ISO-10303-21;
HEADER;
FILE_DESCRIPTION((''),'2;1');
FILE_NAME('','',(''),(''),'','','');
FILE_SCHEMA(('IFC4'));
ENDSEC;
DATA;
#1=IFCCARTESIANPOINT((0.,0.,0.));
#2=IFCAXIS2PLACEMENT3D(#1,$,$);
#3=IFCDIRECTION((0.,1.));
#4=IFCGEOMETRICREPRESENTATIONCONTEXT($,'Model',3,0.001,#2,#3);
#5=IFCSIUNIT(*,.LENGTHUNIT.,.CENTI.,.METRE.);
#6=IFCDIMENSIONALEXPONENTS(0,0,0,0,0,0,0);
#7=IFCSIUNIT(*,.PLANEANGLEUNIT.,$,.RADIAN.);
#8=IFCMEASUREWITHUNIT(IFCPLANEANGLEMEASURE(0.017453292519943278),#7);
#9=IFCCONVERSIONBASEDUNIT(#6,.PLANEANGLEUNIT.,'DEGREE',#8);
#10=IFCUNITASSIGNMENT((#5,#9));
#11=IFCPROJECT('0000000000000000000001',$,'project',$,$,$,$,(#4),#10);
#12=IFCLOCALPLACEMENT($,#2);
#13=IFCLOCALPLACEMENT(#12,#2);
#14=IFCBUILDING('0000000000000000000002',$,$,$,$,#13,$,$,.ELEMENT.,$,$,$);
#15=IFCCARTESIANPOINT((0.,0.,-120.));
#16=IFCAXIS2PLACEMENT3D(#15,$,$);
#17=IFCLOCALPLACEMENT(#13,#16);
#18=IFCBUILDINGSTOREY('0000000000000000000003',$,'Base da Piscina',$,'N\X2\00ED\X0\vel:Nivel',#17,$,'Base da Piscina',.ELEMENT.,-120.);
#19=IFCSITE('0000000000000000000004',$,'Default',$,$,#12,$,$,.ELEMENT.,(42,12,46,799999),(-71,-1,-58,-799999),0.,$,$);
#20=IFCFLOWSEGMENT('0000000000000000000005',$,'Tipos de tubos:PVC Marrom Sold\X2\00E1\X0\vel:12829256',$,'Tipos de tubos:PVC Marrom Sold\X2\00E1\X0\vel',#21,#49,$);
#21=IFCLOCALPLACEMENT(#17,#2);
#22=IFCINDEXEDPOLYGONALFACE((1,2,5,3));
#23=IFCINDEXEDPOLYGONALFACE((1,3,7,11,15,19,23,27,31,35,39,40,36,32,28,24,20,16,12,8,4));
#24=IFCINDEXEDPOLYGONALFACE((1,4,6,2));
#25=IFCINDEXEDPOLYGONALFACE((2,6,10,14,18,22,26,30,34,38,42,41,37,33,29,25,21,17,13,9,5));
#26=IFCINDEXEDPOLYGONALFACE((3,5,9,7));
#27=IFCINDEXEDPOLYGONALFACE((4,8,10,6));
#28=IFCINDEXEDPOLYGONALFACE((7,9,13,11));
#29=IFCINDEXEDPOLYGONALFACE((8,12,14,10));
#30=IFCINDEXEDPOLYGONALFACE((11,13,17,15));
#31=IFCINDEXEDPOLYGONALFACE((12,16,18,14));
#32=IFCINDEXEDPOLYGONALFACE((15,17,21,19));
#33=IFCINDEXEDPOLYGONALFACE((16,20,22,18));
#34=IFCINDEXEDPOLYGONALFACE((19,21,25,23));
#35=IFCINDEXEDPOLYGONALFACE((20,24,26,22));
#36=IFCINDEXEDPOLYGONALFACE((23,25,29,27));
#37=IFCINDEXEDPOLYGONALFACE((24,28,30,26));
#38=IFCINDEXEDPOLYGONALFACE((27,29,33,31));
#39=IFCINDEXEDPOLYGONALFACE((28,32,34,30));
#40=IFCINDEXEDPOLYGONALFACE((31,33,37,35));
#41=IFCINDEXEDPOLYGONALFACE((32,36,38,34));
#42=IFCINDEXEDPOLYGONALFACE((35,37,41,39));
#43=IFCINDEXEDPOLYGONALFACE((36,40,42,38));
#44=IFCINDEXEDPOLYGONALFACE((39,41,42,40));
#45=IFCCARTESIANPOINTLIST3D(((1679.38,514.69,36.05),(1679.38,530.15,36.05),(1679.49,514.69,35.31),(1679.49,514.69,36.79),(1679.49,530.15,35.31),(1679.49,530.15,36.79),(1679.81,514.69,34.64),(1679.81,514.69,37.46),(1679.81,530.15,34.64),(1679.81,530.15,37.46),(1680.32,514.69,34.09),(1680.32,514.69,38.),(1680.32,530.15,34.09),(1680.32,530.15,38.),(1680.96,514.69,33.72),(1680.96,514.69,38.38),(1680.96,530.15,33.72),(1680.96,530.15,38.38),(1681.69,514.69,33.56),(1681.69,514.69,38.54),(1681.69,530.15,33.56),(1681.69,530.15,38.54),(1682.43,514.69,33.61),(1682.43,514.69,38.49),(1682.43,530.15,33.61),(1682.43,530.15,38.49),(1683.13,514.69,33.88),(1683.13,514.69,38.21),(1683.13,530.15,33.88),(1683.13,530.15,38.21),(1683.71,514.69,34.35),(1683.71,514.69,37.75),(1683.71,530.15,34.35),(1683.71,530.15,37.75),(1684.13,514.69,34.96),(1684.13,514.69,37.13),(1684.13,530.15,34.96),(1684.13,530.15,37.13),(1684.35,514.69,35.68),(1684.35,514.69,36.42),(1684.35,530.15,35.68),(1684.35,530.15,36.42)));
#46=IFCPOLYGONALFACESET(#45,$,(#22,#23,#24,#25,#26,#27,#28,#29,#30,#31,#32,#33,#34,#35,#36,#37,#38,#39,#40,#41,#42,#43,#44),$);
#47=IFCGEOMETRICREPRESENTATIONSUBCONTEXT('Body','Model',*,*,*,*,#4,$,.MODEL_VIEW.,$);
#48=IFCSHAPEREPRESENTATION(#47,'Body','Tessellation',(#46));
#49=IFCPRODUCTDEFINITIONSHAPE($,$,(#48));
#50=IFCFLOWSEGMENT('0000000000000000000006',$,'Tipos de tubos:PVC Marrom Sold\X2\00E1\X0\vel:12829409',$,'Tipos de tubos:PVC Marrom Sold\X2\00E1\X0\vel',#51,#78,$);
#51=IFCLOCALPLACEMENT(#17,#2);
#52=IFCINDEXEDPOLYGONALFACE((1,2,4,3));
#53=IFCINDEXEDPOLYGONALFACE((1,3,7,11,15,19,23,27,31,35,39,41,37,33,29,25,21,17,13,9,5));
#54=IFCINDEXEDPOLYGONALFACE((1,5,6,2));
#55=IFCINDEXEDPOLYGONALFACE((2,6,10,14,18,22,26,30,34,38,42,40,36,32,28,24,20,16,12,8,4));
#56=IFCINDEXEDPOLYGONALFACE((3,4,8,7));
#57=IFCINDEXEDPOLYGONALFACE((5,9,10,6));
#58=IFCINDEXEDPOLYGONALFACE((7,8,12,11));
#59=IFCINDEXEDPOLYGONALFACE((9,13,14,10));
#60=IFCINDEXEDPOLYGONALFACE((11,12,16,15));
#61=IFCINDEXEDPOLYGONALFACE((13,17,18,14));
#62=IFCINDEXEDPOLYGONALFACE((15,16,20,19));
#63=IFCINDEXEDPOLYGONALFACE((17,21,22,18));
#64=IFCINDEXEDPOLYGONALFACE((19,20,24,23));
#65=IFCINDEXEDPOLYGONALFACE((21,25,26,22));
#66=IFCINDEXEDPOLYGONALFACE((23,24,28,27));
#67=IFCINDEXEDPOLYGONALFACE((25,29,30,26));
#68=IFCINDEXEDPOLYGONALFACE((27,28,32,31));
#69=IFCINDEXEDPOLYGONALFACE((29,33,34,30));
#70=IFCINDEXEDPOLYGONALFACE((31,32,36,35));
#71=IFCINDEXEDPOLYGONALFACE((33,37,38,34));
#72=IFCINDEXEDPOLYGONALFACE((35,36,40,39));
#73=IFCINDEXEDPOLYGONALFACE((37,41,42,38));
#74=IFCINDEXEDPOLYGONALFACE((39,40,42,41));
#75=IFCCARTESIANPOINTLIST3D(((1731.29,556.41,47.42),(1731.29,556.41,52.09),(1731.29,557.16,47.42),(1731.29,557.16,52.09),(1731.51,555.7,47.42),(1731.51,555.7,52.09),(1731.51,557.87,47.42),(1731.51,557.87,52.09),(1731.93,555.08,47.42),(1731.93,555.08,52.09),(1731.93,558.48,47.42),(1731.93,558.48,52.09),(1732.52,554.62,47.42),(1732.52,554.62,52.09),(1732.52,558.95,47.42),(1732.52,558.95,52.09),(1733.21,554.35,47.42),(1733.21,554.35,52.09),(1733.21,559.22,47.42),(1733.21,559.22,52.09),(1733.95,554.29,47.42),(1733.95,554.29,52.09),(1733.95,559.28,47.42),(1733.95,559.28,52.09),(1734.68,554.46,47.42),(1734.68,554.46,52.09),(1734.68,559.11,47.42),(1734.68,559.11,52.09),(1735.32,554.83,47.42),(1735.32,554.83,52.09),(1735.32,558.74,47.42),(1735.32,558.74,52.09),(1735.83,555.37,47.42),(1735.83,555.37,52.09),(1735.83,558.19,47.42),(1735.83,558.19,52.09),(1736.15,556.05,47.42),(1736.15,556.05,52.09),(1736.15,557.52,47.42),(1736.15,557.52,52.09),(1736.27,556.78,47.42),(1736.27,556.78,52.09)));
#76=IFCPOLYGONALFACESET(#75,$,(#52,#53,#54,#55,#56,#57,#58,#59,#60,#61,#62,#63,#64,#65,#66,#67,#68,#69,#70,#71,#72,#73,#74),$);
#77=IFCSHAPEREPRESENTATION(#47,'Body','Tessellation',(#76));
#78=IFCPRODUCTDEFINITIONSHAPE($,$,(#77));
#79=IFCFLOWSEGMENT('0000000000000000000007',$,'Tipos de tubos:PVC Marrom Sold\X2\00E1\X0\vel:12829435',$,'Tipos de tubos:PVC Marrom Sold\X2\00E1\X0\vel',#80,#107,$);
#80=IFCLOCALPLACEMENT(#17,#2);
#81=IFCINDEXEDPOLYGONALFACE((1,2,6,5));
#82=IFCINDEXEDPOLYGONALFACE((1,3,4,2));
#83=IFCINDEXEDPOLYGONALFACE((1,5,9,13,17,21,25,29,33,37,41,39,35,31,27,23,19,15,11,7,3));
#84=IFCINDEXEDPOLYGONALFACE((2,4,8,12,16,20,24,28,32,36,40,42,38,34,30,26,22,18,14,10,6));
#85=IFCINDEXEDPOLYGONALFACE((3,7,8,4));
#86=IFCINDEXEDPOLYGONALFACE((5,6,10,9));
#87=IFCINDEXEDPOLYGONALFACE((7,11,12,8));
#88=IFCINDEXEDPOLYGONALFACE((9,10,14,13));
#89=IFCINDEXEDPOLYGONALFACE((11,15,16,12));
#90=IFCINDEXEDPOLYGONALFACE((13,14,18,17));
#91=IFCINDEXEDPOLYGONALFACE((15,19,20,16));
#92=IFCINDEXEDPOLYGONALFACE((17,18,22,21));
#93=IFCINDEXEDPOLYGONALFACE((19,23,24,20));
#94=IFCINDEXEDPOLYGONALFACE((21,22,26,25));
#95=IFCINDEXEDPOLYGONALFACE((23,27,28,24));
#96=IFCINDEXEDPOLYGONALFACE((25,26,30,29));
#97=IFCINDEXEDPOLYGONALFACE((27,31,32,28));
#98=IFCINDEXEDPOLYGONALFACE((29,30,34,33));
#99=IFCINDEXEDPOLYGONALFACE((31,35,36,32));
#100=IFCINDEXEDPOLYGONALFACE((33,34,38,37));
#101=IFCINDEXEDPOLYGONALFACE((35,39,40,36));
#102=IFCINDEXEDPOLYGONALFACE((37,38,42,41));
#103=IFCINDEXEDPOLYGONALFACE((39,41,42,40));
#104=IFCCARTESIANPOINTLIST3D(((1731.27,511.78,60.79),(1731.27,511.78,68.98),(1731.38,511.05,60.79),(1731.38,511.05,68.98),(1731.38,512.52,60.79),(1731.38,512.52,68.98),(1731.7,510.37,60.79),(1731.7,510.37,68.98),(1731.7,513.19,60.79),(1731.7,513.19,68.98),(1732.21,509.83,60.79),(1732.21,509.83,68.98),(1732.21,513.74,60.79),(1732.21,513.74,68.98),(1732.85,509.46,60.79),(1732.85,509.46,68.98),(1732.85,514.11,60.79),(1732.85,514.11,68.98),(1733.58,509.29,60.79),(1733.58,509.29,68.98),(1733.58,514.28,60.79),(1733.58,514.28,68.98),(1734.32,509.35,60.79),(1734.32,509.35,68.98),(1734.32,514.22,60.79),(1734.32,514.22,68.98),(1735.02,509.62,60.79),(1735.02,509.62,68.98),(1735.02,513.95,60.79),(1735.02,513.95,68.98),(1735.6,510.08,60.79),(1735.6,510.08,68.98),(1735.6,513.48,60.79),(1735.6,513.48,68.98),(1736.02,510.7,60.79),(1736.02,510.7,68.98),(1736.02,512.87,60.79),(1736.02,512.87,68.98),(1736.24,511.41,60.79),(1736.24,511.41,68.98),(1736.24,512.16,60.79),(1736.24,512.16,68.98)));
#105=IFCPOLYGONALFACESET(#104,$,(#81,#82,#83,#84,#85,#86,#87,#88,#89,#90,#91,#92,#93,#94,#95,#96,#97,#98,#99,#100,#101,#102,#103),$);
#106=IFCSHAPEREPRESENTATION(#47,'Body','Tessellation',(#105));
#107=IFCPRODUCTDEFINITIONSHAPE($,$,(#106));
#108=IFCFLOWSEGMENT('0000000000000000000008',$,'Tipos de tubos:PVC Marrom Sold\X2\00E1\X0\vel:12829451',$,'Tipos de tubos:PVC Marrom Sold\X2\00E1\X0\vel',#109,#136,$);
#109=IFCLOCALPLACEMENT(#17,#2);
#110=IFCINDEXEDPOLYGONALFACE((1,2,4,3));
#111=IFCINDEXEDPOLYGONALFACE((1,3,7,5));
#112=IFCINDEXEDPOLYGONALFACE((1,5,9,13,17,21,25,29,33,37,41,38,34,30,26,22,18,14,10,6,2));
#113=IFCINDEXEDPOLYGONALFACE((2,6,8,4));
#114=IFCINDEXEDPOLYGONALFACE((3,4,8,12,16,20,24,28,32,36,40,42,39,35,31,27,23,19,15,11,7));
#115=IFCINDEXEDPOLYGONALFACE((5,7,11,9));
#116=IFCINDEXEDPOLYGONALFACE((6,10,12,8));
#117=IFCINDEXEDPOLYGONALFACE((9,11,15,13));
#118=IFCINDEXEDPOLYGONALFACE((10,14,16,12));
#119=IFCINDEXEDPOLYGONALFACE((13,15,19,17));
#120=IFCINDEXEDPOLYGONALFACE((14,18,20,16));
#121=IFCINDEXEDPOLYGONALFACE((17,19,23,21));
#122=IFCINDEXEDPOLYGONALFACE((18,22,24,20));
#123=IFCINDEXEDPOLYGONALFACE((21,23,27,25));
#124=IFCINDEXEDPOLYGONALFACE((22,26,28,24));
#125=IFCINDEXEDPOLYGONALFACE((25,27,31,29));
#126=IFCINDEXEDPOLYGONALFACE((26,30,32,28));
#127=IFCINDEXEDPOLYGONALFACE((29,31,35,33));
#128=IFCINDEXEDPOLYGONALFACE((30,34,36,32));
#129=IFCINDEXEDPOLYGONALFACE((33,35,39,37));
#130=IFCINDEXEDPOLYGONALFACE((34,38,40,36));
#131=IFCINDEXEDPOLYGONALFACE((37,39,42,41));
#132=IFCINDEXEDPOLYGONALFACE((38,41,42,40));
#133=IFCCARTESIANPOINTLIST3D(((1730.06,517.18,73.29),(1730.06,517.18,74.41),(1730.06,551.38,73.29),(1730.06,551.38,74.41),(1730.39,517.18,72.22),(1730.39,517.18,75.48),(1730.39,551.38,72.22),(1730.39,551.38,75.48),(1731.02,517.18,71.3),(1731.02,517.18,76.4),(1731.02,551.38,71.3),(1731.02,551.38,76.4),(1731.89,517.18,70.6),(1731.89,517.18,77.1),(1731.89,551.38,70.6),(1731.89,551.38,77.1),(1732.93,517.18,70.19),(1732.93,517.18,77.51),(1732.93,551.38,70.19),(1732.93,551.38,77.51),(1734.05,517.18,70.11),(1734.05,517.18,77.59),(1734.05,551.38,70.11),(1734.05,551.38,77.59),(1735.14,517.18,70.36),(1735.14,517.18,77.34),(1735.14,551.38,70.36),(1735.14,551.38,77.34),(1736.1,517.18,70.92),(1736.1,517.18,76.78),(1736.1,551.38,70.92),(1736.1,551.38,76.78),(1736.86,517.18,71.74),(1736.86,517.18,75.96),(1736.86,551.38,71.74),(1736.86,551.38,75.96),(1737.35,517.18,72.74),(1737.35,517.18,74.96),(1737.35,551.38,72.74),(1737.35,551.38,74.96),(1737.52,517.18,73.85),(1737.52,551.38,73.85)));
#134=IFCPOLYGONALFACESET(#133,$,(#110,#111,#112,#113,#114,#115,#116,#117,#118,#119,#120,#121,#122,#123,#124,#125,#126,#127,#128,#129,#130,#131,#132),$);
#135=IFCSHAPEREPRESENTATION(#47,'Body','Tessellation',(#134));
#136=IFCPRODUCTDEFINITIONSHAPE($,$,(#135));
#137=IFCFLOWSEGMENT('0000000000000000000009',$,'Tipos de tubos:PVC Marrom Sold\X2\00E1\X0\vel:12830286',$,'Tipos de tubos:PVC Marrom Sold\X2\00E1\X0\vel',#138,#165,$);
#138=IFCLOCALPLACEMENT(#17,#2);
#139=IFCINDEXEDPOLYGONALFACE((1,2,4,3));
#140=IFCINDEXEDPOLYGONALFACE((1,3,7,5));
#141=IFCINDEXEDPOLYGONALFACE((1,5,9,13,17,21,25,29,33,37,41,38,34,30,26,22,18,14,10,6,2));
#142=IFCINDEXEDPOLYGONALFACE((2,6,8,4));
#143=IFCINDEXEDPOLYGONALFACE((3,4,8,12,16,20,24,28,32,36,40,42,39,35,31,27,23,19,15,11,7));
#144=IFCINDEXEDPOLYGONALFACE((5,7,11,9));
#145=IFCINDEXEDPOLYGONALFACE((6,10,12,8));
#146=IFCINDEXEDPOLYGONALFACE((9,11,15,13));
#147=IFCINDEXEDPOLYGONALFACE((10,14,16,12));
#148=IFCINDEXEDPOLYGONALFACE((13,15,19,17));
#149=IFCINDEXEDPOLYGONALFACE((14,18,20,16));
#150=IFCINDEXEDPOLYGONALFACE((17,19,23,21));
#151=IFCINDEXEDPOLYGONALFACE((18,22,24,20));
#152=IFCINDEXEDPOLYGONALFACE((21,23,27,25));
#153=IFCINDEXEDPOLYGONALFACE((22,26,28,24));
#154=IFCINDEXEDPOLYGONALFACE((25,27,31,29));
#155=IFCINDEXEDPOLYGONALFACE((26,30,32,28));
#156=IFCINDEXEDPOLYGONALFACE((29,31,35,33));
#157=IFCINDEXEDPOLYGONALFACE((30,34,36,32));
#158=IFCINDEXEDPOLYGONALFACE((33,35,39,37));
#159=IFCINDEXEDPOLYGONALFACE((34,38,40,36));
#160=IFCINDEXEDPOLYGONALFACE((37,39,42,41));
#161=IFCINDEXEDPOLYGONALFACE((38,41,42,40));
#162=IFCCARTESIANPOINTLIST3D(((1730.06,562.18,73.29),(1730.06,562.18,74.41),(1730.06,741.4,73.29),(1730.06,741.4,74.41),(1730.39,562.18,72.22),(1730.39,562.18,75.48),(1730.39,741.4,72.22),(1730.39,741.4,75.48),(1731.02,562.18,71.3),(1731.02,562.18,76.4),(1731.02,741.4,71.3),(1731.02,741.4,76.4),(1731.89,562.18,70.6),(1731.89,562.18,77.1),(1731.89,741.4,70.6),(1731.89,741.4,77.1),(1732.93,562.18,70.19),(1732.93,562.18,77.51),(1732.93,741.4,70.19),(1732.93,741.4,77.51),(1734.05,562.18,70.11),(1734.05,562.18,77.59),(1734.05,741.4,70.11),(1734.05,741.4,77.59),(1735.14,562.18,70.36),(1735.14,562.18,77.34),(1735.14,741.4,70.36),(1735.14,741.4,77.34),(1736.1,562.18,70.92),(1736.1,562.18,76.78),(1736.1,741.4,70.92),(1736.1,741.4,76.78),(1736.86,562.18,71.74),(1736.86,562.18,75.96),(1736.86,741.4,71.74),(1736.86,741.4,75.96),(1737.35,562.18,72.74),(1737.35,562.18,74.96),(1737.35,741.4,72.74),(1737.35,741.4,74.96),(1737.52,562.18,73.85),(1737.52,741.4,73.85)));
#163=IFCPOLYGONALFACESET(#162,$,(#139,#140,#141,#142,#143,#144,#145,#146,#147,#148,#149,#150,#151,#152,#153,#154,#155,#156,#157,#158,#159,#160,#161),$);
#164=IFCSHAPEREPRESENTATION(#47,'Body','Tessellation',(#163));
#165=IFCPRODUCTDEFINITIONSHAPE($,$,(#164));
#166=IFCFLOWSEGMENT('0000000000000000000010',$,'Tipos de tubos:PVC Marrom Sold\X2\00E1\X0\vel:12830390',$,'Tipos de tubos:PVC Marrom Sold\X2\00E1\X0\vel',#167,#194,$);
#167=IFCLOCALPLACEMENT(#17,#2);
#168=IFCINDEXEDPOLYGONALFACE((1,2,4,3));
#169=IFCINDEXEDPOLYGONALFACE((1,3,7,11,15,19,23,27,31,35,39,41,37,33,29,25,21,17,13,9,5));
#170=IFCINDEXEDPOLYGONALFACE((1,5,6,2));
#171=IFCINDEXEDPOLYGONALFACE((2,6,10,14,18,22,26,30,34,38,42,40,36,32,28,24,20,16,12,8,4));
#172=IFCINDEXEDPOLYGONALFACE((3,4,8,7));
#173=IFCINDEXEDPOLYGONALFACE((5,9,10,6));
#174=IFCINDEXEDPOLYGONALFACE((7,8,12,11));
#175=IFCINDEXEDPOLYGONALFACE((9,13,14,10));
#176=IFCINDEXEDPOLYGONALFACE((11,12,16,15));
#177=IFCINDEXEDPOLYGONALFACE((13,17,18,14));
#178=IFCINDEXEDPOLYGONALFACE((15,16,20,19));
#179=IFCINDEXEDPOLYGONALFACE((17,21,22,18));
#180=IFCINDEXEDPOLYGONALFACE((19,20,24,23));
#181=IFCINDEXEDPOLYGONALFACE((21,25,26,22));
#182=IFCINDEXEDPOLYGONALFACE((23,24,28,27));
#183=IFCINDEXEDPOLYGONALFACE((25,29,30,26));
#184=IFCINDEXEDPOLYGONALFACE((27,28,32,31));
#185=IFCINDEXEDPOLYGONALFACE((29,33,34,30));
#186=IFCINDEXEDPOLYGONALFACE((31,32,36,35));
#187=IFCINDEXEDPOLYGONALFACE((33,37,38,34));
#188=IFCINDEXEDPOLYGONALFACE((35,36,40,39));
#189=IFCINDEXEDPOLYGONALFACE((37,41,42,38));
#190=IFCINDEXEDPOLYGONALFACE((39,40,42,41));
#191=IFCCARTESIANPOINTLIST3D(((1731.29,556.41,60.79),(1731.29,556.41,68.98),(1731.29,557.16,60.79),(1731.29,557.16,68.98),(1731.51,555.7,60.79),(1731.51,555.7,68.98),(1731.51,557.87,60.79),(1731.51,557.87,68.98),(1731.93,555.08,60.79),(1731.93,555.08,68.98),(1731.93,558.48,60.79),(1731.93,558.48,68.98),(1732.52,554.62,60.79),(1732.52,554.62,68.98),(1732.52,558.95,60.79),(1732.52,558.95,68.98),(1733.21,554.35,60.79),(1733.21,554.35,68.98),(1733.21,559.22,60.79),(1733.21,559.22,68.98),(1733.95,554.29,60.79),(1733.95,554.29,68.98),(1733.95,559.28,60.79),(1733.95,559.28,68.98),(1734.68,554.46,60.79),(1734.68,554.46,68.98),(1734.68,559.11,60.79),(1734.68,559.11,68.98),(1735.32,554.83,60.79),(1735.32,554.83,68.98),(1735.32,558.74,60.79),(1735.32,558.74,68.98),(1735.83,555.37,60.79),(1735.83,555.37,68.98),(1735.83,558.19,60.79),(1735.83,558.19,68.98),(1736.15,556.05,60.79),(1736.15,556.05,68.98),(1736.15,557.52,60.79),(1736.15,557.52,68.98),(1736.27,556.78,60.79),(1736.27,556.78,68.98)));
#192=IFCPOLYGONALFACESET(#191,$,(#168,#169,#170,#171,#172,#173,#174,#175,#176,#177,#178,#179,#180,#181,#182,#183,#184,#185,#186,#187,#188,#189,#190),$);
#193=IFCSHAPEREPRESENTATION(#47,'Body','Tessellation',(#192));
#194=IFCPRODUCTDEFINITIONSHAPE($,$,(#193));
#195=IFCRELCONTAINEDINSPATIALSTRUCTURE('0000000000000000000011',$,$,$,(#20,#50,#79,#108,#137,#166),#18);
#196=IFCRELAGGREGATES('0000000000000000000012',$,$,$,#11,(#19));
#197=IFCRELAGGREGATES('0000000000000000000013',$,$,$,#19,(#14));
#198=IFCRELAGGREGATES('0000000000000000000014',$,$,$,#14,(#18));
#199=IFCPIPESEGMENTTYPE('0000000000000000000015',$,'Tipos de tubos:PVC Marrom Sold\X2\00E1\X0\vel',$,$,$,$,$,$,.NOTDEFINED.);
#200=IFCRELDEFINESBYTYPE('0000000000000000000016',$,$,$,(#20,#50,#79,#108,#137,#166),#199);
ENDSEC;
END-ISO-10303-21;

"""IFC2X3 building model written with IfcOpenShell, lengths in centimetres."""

from ifc_helpers import new_model, entity, si_unit, converted_unit, direction, frame, frame_2d, origin, origin_2d_with_axis, place, context, subcontext, project, spatial, circle, extrude, type_object, element, save


model = new_model("IFC2X3")

# Units and contexts
model_context = context("Model", 3, precision=0.001, world=origin(), true_north=direction((0.0, 1.0)))
body_context = subcontext(model_context, "Body", "Model", "MODEL_VIEW")
ifc_project = project(units=[si_unit("LENGTHUNIT", "METRE", prefix="CENTI"), converted_unit("PLANEANGLEUNIT", "DEGREE", entity("IfcPlaneAngleMeasure", 0.017453292519943278), si_unit("PLANEANGLEUNIT", "RADIAN"), dimensions=[0, 0, 0, 0, 0, 0, 0])], contexts=[model_context])

# Site, building, storey
site_placement = place(None, origin())
site = spatial("IfcSite", under=ifc_project, at=site_placement, Name="Default", CompositionType="ELEMENT", RefLatitude=(42, 12, 46, 799999), RefLongitude=(-71, -1, -58, -799999), RefElevation=0.0)
building_placement = place(site_placement, origin())
building = spatial("IfcBuilding", under=site, at=building_placement, CompositionType="ELEMENT")
storey_placement = place(building_placement, frame((0.0, 0.0, -120.0)))
storey = spatial("IfcBuildingStorey", under=building, at=storey_placement, Name="Base da Piscina", ObjectType="Nível:Nivel", LongName="Base da Piscina", CompositionType="ELEMENT", Elevation=-120.0)

# Flow segments
pipe_segment_type = type_object("IfcPipeSegmentType", Name="Tipos de tubos:PVC Marrom Soldável", PredefinedType="NOTDEFINED")
flow_segment_1_placement = place(storey_placement, origin())
element("IfcFlowSegment", 1, at=flow_segment_1_placement, inside=storey, type_object=pipe_segment_type, Name="Tipos de tubos:PVC Marrom Soldável:12829256", ObjectType="Tipos de tubos:PVC Marrom Soldável", context=body_context, shape_type="SweptSolid", body=[
    extrude(circle(Radius=2.5, at=origin_2d_with_axis()), frame((1681.88, 514.69, 36.05), z_axis=(0.0, 1.0, 0.0), x_axis=(-1.0, 0.0, 0.0)), (0.0, 0.0, 1.0), 15.46),
])
flow_segment_2_placement = place(storey_placement, origin())
element("IfcFlowSegment", 2, at=flow_segment_2_placement, inside=storey, type_object=pipe_segment_type, Name="Tipos de tubos:PVC Marrom Soldável:12829409", ObjectType="Tipos de tubos:PVC Marrom Soldável", context=body_context, shape_type="SweptSolid", body=[
    extrude(circle(Radius=2.5, at=frame_2d((0.0, 0.0), x_axis=(1.0, 0.0))), frame((1733.77, 556.78, 47.42)), (0.0, 0.0, 1.0), 4.67),
])
flow_segment_3_placement = place(storey_placement, origin())
element("IfcFlowSegment", 3, at=flow_segment_3_placement, inside=storey, type_object=pipe_segment_type, Name="Tipos de tubos:PVC Marrom Soldável:12829435", ObjectType="Tipos de tubos:PVC Marrom Soldável", context=body_context, shape_type="SweptSolid", body=[
    extrude(circle(Radius=2.5, at=origin_2d_with_axis()), frame((1733.77, 511.78, 60.79), z_axis=(0.0, 0.0, 1.0), x_axis=(-1.0, 0.0, 0.0)), (0.0, 0.0, 1.0), 8.19),
])
flow_segment_4_placement = place(storey_placement, origin())
element("IfcFlowSegment", 4, at=flow_segment_4_placement, inside=storey, type_object=pipe_segment_type, Name="Tipos de tubos:PVC Marrom Soldável:12829451", ObjectType="Tipos de tubos:PVC Marrom Soldável", context=body_context, shape_type="SweptSolid", body=[
    extrude(circle(Radius=3.75, at=origin_2d_with_axis()), frame((1733.77, 517.18, 73.85), z_axis=(0.0, 1.0, 0.0), x_axis=(1.0, 0.0, 0.0)), (0.0, 0.0, 1.0), 34.2),
])
flow_segment_5_placement = place(storey_placement, origin())
element("IfcFlowSegment", 5, at=flow_segment_5_placement, inside=storey, type_object=pipe_segment_type, Name="Tipos de tubos:PVC Marrom Soldável:12830286", ObjectType="Tipos de tubos:PVC Marrom Soldável", context=body_context, shape_type="SweptSolid", body=[
    extrude(circle(Radius=3.75, at=origin_2d_with_axis()), frame((1733.77, 562.18, 73.85), z_axis=(0.0, 1.0, 0.0), x_axis=(1.0, 0.0, 0.0)), (0.0, 0.0, 1.0), 179.22),
])
flow_segment_6_placement = place(storey_placement, origin())
element("IfcFlowSegment", 6, at=flow_segment_6_placement, inside=storey, type_object=pipe_segment_type, Name="Tipos de tubos:PVC Marrom Soldável:12830390", ObjectType="Tipos de tubos:PVC Marrom Soldável", context=body_context, shape_type="SweptSolid", body=[
    extrude(circle(Radius=2.5, at=frame_2d((0.0, 0.0), x_axis=(1.0, 0.0))), frame((1733.77, 556.78, 60.79)), (0.0, 0.0, 1.0), 8.19),
])

save(model, "model.ifc")
